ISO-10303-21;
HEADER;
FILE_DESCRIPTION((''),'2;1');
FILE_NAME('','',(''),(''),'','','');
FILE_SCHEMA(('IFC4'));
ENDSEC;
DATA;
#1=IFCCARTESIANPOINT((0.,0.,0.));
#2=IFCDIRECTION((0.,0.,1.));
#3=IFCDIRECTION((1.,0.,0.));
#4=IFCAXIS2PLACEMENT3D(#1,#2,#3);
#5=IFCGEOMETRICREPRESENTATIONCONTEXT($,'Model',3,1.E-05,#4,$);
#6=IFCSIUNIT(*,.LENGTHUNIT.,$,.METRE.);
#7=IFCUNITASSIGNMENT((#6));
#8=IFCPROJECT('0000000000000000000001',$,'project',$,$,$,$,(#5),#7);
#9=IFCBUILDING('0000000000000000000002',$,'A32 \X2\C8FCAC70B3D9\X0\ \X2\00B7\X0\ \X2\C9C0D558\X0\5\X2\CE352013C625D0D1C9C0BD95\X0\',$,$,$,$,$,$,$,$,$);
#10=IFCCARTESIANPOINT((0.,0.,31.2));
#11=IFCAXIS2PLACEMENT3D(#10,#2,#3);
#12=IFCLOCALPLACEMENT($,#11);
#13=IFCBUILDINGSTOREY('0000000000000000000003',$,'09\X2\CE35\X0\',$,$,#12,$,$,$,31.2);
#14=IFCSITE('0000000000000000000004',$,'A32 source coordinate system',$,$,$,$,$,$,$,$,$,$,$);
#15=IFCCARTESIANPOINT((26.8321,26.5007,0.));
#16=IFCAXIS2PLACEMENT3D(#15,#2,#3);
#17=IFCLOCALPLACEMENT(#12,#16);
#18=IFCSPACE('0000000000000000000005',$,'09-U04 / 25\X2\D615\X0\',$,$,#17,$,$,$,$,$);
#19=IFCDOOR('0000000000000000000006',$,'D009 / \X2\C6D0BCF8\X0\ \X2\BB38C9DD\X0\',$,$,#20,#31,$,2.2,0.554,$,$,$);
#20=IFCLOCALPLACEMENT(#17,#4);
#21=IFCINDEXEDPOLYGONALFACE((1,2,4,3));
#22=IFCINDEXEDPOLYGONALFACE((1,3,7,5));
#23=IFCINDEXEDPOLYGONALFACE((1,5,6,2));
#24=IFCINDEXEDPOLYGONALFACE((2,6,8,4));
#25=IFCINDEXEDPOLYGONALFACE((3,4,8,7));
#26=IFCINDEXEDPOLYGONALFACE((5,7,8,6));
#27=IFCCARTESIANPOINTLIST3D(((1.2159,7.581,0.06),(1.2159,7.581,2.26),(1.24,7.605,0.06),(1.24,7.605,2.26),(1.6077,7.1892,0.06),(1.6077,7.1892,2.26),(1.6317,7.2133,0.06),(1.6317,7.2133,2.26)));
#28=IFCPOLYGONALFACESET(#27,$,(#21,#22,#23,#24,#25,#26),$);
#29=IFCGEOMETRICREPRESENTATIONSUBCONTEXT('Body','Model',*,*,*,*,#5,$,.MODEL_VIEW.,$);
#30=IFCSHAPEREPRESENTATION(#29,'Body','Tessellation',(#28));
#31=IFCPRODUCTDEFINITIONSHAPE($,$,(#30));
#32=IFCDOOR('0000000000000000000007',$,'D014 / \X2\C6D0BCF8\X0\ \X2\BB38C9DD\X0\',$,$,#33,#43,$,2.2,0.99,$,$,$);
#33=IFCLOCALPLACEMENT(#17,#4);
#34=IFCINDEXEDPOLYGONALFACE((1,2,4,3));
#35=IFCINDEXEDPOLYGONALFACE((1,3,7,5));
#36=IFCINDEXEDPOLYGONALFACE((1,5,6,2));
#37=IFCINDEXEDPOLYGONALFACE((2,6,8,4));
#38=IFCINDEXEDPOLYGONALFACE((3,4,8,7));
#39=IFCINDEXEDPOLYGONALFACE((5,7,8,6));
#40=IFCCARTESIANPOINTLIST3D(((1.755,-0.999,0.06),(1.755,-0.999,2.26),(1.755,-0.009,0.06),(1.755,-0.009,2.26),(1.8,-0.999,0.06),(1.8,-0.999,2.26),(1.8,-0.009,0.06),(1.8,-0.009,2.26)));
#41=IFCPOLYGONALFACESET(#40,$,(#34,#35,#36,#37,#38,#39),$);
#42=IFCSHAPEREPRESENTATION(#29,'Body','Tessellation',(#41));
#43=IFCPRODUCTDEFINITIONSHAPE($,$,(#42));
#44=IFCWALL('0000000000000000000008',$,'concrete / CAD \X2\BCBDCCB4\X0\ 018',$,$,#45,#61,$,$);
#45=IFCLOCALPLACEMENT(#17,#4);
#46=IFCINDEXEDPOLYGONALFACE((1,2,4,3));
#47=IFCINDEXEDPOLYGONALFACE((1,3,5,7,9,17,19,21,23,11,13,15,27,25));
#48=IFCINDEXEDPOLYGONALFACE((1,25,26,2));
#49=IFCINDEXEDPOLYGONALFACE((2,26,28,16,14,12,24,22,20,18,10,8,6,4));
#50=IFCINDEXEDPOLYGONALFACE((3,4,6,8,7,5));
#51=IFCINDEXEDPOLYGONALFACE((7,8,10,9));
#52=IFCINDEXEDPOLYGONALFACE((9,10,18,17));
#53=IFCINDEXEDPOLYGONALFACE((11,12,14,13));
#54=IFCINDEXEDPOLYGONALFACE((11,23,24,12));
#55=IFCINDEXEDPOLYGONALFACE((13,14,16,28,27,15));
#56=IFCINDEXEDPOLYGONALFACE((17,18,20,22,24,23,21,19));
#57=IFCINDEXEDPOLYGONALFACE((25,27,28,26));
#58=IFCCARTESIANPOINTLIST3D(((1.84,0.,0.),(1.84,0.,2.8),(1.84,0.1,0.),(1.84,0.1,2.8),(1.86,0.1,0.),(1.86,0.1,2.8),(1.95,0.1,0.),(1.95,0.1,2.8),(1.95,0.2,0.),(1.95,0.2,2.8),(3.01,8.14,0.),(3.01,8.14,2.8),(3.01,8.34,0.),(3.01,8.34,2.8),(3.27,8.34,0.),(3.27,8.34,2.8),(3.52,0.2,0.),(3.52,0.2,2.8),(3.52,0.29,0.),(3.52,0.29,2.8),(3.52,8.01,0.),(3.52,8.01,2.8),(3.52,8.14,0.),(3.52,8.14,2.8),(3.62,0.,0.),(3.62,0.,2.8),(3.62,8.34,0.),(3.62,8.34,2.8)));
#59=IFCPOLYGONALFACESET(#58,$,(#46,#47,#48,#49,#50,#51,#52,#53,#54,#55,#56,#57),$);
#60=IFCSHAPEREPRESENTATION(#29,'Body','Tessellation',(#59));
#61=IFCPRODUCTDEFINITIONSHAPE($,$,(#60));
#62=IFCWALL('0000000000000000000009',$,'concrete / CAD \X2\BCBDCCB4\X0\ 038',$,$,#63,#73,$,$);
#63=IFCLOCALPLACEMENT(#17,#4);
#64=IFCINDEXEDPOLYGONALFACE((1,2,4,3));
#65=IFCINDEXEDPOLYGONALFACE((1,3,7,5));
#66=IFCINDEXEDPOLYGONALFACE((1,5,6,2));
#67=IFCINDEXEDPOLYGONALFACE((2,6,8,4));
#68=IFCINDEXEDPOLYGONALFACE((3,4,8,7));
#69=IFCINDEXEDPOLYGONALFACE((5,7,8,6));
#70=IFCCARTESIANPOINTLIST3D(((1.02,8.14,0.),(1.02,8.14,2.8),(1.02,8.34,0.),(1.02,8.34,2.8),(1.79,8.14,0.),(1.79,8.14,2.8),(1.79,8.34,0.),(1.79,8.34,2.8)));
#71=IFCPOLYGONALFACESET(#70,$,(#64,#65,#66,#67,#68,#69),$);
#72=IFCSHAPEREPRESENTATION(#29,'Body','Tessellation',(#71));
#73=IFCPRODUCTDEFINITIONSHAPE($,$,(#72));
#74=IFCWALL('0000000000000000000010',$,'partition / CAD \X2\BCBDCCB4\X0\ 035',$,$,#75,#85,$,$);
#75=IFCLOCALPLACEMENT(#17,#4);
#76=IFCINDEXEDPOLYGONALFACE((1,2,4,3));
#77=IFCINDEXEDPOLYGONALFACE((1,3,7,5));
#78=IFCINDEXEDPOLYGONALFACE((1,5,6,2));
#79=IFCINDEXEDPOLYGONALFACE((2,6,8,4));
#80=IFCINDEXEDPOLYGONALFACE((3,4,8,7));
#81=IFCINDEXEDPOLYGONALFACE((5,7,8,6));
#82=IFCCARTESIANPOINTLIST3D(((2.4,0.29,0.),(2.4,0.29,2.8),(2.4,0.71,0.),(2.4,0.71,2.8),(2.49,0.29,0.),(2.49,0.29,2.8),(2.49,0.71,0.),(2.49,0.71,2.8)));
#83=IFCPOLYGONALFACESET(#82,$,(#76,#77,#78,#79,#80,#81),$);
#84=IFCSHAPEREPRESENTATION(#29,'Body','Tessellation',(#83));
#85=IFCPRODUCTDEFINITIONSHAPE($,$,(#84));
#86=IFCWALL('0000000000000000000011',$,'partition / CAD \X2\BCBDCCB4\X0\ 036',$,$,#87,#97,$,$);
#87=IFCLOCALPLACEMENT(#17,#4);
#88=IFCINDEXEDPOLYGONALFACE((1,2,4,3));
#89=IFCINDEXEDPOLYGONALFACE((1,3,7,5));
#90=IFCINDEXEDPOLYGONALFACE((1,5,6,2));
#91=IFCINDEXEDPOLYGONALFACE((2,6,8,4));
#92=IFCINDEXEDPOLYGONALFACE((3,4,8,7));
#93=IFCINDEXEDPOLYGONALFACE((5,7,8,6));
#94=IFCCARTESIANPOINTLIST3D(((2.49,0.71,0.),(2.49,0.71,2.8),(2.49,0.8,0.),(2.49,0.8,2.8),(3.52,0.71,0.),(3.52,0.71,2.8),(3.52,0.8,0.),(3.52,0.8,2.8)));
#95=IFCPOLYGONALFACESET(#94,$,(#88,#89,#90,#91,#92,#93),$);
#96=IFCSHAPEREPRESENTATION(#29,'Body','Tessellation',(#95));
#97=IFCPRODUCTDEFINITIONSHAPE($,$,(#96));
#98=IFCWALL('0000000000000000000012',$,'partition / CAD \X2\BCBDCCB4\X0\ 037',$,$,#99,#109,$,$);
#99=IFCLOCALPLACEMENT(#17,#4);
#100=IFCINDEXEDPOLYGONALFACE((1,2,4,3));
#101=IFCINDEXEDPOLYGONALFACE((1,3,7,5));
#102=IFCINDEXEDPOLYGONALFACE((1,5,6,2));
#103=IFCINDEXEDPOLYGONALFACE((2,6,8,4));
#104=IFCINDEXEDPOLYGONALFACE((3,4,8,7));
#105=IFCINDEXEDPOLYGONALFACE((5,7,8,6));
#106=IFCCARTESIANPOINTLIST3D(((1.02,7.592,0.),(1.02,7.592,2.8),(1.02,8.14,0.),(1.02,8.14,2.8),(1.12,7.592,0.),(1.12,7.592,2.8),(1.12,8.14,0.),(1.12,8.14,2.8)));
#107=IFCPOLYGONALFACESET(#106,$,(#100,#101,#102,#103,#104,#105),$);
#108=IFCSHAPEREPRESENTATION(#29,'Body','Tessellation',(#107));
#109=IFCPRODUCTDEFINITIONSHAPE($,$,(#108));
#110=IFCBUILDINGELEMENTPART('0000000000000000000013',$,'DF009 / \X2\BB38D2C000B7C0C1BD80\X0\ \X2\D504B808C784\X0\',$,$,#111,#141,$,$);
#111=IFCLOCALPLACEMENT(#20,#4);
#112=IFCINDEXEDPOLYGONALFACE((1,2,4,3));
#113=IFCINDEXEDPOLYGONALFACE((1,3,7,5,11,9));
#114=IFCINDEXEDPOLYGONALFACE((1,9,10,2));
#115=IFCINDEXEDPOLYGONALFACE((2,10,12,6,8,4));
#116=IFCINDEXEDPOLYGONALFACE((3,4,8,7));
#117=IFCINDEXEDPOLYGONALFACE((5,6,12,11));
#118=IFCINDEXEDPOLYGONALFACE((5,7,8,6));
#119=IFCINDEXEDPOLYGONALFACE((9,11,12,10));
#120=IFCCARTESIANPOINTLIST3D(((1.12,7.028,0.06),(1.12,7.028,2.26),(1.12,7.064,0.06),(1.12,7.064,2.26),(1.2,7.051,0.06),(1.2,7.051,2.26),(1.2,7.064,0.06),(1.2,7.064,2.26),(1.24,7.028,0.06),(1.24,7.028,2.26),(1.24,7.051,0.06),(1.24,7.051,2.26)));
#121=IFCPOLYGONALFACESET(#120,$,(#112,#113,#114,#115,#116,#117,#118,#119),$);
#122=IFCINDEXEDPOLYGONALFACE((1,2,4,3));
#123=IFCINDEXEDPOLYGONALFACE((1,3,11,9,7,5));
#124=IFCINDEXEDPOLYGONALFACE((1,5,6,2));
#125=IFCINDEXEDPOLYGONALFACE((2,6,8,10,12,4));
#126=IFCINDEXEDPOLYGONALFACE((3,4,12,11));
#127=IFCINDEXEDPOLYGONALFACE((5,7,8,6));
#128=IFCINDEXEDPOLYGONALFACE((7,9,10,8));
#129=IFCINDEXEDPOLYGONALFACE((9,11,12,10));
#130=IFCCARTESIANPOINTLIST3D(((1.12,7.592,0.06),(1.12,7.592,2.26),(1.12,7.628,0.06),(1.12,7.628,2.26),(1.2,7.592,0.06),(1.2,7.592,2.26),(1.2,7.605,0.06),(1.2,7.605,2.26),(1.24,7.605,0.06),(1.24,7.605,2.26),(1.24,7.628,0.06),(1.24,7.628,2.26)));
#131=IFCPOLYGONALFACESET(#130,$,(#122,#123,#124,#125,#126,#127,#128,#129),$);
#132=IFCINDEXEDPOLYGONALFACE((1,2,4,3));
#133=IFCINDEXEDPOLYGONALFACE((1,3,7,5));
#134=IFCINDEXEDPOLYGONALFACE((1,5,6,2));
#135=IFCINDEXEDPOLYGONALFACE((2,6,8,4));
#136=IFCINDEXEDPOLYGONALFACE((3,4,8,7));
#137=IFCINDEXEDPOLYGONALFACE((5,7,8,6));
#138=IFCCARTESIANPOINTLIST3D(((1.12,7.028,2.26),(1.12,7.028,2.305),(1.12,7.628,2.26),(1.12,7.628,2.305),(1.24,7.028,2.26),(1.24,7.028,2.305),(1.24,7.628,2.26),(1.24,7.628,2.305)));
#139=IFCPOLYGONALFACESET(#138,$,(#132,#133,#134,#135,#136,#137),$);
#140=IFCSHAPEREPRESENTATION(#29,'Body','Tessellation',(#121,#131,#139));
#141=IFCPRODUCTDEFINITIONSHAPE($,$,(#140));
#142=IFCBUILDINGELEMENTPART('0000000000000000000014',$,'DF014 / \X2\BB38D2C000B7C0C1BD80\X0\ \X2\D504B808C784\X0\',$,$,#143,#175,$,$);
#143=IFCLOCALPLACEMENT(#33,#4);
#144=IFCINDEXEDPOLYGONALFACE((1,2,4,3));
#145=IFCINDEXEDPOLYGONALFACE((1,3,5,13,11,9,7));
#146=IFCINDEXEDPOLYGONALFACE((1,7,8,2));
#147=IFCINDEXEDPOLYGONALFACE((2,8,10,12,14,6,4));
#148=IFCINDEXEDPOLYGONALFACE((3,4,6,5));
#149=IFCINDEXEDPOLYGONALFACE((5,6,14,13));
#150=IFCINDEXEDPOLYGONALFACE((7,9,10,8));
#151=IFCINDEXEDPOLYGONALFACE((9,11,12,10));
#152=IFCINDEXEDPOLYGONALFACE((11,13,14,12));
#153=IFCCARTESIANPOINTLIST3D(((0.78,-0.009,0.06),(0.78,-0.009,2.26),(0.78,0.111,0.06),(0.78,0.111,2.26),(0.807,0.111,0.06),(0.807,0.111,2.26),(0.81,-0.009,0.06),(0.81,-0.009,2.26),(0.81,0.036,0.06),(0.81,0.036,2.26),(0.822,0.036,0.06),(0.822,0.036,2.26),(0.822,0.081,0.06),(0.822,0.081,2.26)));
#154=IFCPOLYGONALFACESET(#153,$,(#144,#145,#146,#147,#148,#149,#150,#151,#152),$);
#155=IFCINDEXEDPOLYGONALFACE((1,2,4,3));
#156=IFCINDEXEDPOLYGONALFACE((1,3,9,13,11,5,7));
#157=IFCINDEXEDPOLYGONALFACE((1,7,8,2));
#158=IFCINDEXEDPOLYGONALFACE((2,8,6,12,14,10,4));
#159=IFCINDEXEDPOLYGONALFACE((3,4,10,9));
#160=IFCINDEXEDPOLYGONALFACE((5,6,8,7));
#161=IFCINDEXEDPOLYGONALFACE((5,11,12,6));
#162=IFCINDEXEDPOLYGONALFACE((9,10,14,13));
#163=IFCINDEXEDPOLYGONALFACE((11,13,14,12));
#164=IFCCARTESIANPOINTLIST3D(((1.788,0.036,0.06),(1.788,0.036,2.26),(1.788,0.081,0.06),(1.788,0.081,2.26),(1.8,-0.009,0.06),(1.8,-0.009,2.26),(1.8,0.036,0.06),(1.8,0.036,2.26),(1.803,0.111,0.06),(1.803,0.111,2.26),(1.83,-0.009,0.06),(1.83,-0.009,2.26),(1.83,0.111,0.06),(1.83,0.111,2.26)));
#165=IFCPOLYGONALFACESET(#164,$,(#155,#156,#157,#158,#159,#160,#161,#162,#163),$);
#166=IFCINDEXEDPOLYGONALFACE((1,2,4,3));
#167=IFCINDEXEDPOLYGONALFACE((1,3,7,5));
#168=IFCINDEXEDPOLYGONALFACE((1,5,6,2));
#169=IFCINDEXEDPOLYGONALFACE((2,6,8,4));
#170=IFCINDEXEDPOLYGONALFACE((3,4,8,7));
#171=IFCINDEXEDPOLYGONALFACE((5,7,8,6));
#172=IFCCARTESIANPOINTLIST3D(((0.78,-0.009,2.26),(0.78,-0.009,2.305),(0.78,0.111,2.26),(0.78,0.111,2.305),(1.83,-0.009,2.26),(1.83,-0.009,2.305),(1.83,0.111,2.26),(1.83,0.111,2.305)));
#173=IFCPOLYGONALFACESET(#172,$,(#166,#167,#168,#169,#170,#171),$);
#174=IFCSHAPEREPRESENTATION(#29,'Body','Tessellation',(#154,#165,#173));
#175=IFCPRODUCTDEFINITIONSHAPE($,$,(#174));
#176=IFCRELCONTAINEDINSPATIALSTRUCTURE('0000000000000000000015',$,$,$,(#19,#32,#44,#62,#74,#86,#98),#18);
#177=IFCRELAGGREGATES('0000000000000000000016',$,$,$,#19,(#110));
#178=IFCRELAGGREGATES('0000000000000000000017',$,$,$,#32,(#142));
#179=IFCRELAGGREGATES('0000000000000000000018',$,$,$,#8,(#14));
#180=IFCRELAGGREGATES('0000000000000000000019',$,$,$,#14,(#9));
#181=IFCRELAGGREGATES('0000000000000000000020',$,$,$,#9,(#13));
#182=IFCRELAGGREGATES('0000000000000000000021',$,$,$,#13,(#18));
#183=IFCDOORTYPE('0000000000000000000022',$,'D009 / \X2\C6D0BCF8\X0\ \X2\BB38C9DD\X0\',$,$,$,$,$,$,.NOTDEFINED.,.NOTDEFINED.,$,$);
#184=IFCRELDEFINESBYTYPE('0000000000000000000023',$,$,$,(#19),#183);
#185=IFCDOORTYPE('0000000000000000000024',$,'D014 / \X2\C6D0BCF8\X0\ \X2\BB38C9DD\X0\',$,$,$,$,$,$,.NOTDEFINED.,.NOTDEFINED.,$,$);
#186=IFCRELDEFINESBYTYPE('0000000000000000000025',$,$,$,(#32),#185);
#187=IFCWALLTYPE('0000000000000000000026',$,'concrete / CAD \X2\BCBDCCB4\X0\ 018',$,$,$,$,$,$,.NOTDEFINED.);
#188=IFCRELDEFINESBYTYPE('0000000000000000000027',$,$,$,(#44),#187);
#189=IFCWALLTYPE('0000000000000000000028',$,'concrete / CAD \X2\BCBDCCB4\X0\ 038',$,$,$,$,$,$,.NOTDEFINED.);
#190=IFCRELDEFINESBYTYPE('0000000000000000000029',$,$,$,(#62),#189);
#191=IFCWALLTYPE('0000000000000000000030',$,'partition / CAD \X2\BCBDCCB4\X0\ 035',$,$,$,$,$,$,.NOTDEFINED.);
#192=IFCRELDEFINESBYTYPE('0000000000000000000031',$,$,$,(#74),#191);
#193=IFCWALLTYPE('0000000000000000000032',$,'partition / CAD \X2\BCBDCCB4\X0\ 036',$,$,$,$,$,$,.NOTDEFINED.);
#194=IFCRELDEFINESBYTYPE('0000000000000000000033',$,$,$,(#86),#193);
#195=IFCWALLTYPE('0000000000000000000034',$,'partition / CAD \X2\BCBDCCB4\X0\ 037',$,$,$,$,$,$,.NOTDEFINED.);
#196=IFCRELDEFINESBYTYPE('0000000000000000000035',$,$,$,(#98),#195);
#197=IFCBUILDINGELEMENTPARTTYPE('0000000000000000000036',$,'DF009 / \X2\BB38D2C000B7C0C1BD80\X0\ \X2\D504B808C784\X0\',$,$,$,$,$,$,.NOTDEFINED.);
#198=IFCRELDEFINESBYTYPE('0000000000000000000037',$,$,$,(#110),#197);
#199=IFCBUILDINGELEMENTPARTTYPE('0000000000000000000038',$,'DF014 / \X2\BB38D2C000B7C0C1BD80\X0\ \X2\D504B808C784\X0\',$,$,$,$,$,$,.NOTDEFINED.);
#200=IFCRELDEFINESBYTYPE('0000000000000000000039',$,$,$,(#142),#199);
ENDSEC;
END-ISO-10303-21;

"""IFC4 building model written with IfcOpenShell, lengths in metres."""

from ifc_helpers import new_model, si_unit, frame, origin, origin_with_axes, place, context, subcontext, project, spatial, polyline, outline, extrude, source, transform, mapped, type_object, type_shapes, element, aggregate, save


model = new_model("IFC4")

# Units and contexts
model_context = context("Model", 3, precision=1e-05, world=origin_with_axes())
body_context = subcontext(model_context, "Body", "Model", "MODEL_VIEW")
ifc_project = project(units=[si_unit("LENGTHUNIT", "METRE")], contexts=[model_context])

# Site, building, storey, space
storey_placement = place(None, frame((0.0, 0.0, 31.2), z_axis=(0.0, 0.0, 1.0), x_axis=(1.0, 0.0, 0.0)))
space_placement = place(storey_placement, frame((26.8321, 26.5007, 0.0), z_axis=(0.0, 0.0, 1.0), x_axis=(1.0, 0.0, 0.0)))
site = spatial("IfcSite", under=ifc_project, Name="A32 source coordinate system")
building = spatial("IfcBuilding", under=site, Name="A32 주거동 · 지하5층–옥탑지붕")
storey = spatial("IfcBuildingStorey", under=building, at=storey_placement, Name="09층", Elevation=31.2)
space = spatial("IfcSpace", under=storey, at=space_placement, Name="09-U04 / 25형")

# Doors
door_type_1 = type_object("IfcDoorType", Name="D009 / 원본 문짝", OperationType="NOTDEFINED", PredefinedType="NOTDEFINED")
shared_shape_1 = source(origin(), body_context, "Body", "SweptSolid", [
    extrude(outline(polyline([(1.24, 7.605), (1.6317, 7.2133), (1.6077, 7.1892), (1.2159, 7.581), (1.24, 7.605)])), frame((0.0, 0.0, 0.06)), (0.0, 0.0, 1.0), 2.2),
])
type_shapes(door_type_1, [shared_shape_1])
door_1_placement = place(space_placement, origin_with_axes())
door_1 = element("IfcDoor", 1, at=door_1_placement, inside=space, type_object=door_type_1, Name="D009 / 원본 문짝", OverallHeight=2.2, OverallWidth=0.554, context=body_context, shape_type="MappedRepresentation", body=[
    mapped(shared_shape_1, transform((0.0, 0.0, 0.0), scale=1.0)),
])
door_type_2 = type_object("IfcDoorType", Name="D014 / 원본 문짝", OperationType="NOTDEFINED", PredefinedType="NOTDEFINED")
shared_shape_2 = source(origin(), body_context, "Body", "SweptSolid", [
    extrude(outline(polyline([(1.8, -0.009), (1.8, -0.999), (1.755, -0.999), (1.755, -0.009), (1.8, -0.009)])), frame((0.0, 0.0, 0.06)), (0.0, 0.0, 1.0), 2.2),
])
type_shapes(door_type_2, [shared_shape_2])
door_2_placement = place(space_placement, origin_with_axes())
door_2 = element("IfcDoor", 2, at=door_2_placement, inside=space, type_object=door_type_2, Name="D014 / 원본 문짝", OverallHeight=2.2, OverallWidth=0.99, context=body_context, shape_type="MappedRepresentation", body=[
    mapped(shared_shape_2, transform((0.0, 0.0, 0.0), scale=1.0)),
])

# Walls
wall_type_1 = type_object("IfcWallType", Name="concrete / CAD 벽체 018", PredefinedType="NOTDEFINED")
shared_shape_3 = source(origin(), body_context, "Body", "SweptSolid", [
    extrude(outline(polyline([(3.27, 8.34), (3.27, 8.34), (3.62, 8.34), (3.62, 0.0), (1.84, 0.0), (1.84, 0.1), (1.86, 0.1), (1.95, 0.1), (1.95, 0.2), (3.52, 0.2), (3.52, 0.29), (3.52, 8.01), (3.52, 8.14), (3.01, 8.14), (3.01, 8.34), (3.27, 8.34)])), origin(), (0.0, 0.0, 1.0), 2.8),
])
type_shapes(wall_type_1, [shared_shape_3])
wall_1_placement = place(space_placement, origin_with_axes())
element("IfcWall", 3, at=wall_1_placement, inside=space, type_object=wall_type_1, Name="concrete / CAD 벽체 018", context=body_context, shape_type="MappedRepresentation", body=[
    mapped(shared_shape_3, transform((0.0, 0.0, 0.0), scale=1.0)),
])
wall_type_2 = type_object("IfcWallType", Name="concrete / CAD 벽체 038", PredefinedType="NOTDEFINED")
shared_shape_4 = source(origin(), body_context, "Body", "SweptSolid", [
    extrude(outline(polyline([(1.02, 8.14), (1.02, 8.34), (1.79, 8.34), (1.79, 8.14), (1.02, 8.14)])), origin(), (0.0, 0.0, 1.0), 2.8),
])
type_shapes(wall_type_2, [shared_shape_4])
wall_2_placement = place(space_placement, origin_with_axes())
element("IfcWall", 4, at=wall_2_placement, inside=space, type_object=wall_type_2, Name="concrete / CAD 벽체 038", context=body_context, shape_type="MappedRepresentation", body=[
    mapped(shared_shape_4, transform((0.0, 0.0, 0.0), scale=1.0)),
])
wall_type_3 = type_object("IfcWallType", Name="partition / CAD 벽체 035", PredefinedType="NOTDEFINED")
shared_shape_5 = source(origin(), body_context, "Body", "SweptSolid", [
    extrude(outline(polyline([(2.49, 0.71), (2.49, 0.29), (2.4, 0.29), (2.4, 0.71), (2.49, 0.71)])), origin(), (0.0, 0.0, 1.0), 2.8),
])
type_shapes(wall_type_3, [shared_shape_5])
wall_3_placement = place(space_placement, origin_with_axes())
element("IfcWall", 5, at=wall_3_placement, inside=space, type_object=wall_type_3, Name="partition / CAD 벽체 035", context=body_context, shape_type="MappedRepresentation", body=[
    mapped(shared_shape_5, transform((0.0, 0.0, 0.0), scale=1.0)),
])
wall_type_4 = type_object("IfcWallType", Name="partition / CAD 벽체 036", PredefinedType="NOTDEFINED")
shared_shape_6 = source(origin(), body_context, "Body", "SweptSolid", [
    extrude(outline(polyline([(2.49, 0.8), (3.52, 0.8), (3.52, 0.71), (2.49, 0.71), (2.49, 0.8)])), origin(), (0.0, 0.0, 1.0), 2.8),
])
type_shapes(wall_type_4, [shared_shape_6])
wall_4_placement = place(space_placement, origin_with_axes())
element("IfcWall", 6, at=wall_4_placement, inside=space, type_object=wall_type_4, Name="partition / CAD 벽체 036", context=body_context, shape_type="MappedRepresentation", body=[
    mapped(shared_shape_6, transform((0.0, 0.0, 0.0), scale=1.0)),
])
wall_type_5 = type_object("IfcWallType", Name="partition / CAD 벽체 037", PredefinedType="NOTDEFINED")
shared_shape_7 = source(origin(), body_context, "Body", "SweptSolid", [
    extrude(outline(polyline([(1.02, 7.592), (1.02, 8.14), (1.12, 8.14), (1.12, 7.592), (1.02, 7.592)])), origin(), (0.0, 0.0, 1.0), 2.8),
])
type_shapes(wall_type_5, [shared_shape_7])
wall_5_placement = place(space_placement, origin_with_axes())
element("IfcWall", 7, at=wall_5_placement, inside=space, type_object=wall_type_5, Name="partition / CAD 벽체 037", context=body_context, shape_type="MappedRepresentation", body=[
    mapped(shared_shape_7, transform((0.0, 0.0, 0.0), scale=1.0)),
])

# Building element parts
building_element_part_type_1 = type_object("IfcBuildingElementPartType", Name="DF009 / 문틀·상부 프레임", PredefinedType="NOTDEFINED")
shared_shape_8 = source(origin(), body_context, "Body", "SweptSolid", [
    extrude(outline(polyline([(1.12, 7.064), (1.2, 7.064), (1.2, 7.051), (1.24, 7.051), (1.24, 7.028), (1.12, 7.028), (1.12, 7.064)])), frame((0.0, 0.0, 0.06)), (0.0, 0.0, 1.0), 2.2),
    extrude(outline(polyline([(1.24, 7.628), (1.24, 7.605), (1.2, 7.605), (1.2, 7.592), (1.12, 7.592), (1.12, 7.628), (1.24, 7.628)])), frame((0.0, 0.0, 0.06)), (0.0, 0.0, 1.0), 2.2),
    extrude(outline(polyline([(1.12, 7.028), (1.12, 7.628), (1.24, 7.628), (1.24, 7.028), (1.12, 7.028)])), frame((0.0, 0.0, 2.26)), (0.0, 0.0, 1.0), 0.045),
])
type_shapes(building_element_part_type_1, [shared_shape_8])
building_element_part_1_placement = place(door_1_placement, origin_with_axes())
building_element_part_1 = element("IfcBuildingElementPart", 8, at=building_element_part_1_placement, type_object=building_element_part_type_1, Name="DF009 / 문틀·상부 프레임", context=body_context, shape_type="MappedRepresentation", body=[
    mapped(shared_shape_8, transform((0.0, 0.0, 0.0), scale=1.0)),
])
aggregate(door_1, [building_element_part_1])
building_element_part_type_2 = type_object("IfcBuildingElementPartType", Name="DF014 / 문틀·상부 프레임", PredefinedType="NOTDEFINED")
shared_shape_9 = source(origin(), body_context, "Body", "SweptSolid", [
    extrude(outline(polyline([(0.78, 0.111), (0.807, 0.111), (0.822, 0.081), (0.822, 0.036), (0.81, 0.036), (0.81, -0.009), (0.78, -0.009), (0.78, 0.111)])), frame((0.0, 0.0, 0.06)), (0.0, 0.0, 1.0), 2.2),
    extrude(outline(polyline([(1.8, -0.009), (1.8, 0.036), (1.788, 0.036), (1.788, 0.081), (1.803, 0.111), (1.83, 0.111), (1.83, -0.009), (1.8, -0.009)])), frame((0.0, 0.0, 0.06)), (0.0, 0.0, 1.0), 2.2),
    extrude(outline(polyline([(0.78, -0.009), (0.78, 0.111), (1.83, 0.111), (1.83, -0.009), (0.78, -0.009)])), frame((0.0, 0.0, 2.26)), (0.0, 0.0, 1.0), 0.045),
])
type_shapes(building_element_part_type_2, [shared_shape_9])
building_element_part_2_placement = place(door_2_placement, origin_with_axes())
building_element_part_2 = element("IfcBuildingElementPart", 9, at=building_element_part_2_placement, type_object=building_element_part_type_2, Name="DF014 / 문틀·상부 프레임", context=body_context, shape_type="MappedRepresentation", body=[
    mapped(shared_shape_9, transform((0.0, 0.0, 0.0), scale=1.0)),
])
aggregate(door_2, [building_element_part_2])

save(model, "model.ifc")
